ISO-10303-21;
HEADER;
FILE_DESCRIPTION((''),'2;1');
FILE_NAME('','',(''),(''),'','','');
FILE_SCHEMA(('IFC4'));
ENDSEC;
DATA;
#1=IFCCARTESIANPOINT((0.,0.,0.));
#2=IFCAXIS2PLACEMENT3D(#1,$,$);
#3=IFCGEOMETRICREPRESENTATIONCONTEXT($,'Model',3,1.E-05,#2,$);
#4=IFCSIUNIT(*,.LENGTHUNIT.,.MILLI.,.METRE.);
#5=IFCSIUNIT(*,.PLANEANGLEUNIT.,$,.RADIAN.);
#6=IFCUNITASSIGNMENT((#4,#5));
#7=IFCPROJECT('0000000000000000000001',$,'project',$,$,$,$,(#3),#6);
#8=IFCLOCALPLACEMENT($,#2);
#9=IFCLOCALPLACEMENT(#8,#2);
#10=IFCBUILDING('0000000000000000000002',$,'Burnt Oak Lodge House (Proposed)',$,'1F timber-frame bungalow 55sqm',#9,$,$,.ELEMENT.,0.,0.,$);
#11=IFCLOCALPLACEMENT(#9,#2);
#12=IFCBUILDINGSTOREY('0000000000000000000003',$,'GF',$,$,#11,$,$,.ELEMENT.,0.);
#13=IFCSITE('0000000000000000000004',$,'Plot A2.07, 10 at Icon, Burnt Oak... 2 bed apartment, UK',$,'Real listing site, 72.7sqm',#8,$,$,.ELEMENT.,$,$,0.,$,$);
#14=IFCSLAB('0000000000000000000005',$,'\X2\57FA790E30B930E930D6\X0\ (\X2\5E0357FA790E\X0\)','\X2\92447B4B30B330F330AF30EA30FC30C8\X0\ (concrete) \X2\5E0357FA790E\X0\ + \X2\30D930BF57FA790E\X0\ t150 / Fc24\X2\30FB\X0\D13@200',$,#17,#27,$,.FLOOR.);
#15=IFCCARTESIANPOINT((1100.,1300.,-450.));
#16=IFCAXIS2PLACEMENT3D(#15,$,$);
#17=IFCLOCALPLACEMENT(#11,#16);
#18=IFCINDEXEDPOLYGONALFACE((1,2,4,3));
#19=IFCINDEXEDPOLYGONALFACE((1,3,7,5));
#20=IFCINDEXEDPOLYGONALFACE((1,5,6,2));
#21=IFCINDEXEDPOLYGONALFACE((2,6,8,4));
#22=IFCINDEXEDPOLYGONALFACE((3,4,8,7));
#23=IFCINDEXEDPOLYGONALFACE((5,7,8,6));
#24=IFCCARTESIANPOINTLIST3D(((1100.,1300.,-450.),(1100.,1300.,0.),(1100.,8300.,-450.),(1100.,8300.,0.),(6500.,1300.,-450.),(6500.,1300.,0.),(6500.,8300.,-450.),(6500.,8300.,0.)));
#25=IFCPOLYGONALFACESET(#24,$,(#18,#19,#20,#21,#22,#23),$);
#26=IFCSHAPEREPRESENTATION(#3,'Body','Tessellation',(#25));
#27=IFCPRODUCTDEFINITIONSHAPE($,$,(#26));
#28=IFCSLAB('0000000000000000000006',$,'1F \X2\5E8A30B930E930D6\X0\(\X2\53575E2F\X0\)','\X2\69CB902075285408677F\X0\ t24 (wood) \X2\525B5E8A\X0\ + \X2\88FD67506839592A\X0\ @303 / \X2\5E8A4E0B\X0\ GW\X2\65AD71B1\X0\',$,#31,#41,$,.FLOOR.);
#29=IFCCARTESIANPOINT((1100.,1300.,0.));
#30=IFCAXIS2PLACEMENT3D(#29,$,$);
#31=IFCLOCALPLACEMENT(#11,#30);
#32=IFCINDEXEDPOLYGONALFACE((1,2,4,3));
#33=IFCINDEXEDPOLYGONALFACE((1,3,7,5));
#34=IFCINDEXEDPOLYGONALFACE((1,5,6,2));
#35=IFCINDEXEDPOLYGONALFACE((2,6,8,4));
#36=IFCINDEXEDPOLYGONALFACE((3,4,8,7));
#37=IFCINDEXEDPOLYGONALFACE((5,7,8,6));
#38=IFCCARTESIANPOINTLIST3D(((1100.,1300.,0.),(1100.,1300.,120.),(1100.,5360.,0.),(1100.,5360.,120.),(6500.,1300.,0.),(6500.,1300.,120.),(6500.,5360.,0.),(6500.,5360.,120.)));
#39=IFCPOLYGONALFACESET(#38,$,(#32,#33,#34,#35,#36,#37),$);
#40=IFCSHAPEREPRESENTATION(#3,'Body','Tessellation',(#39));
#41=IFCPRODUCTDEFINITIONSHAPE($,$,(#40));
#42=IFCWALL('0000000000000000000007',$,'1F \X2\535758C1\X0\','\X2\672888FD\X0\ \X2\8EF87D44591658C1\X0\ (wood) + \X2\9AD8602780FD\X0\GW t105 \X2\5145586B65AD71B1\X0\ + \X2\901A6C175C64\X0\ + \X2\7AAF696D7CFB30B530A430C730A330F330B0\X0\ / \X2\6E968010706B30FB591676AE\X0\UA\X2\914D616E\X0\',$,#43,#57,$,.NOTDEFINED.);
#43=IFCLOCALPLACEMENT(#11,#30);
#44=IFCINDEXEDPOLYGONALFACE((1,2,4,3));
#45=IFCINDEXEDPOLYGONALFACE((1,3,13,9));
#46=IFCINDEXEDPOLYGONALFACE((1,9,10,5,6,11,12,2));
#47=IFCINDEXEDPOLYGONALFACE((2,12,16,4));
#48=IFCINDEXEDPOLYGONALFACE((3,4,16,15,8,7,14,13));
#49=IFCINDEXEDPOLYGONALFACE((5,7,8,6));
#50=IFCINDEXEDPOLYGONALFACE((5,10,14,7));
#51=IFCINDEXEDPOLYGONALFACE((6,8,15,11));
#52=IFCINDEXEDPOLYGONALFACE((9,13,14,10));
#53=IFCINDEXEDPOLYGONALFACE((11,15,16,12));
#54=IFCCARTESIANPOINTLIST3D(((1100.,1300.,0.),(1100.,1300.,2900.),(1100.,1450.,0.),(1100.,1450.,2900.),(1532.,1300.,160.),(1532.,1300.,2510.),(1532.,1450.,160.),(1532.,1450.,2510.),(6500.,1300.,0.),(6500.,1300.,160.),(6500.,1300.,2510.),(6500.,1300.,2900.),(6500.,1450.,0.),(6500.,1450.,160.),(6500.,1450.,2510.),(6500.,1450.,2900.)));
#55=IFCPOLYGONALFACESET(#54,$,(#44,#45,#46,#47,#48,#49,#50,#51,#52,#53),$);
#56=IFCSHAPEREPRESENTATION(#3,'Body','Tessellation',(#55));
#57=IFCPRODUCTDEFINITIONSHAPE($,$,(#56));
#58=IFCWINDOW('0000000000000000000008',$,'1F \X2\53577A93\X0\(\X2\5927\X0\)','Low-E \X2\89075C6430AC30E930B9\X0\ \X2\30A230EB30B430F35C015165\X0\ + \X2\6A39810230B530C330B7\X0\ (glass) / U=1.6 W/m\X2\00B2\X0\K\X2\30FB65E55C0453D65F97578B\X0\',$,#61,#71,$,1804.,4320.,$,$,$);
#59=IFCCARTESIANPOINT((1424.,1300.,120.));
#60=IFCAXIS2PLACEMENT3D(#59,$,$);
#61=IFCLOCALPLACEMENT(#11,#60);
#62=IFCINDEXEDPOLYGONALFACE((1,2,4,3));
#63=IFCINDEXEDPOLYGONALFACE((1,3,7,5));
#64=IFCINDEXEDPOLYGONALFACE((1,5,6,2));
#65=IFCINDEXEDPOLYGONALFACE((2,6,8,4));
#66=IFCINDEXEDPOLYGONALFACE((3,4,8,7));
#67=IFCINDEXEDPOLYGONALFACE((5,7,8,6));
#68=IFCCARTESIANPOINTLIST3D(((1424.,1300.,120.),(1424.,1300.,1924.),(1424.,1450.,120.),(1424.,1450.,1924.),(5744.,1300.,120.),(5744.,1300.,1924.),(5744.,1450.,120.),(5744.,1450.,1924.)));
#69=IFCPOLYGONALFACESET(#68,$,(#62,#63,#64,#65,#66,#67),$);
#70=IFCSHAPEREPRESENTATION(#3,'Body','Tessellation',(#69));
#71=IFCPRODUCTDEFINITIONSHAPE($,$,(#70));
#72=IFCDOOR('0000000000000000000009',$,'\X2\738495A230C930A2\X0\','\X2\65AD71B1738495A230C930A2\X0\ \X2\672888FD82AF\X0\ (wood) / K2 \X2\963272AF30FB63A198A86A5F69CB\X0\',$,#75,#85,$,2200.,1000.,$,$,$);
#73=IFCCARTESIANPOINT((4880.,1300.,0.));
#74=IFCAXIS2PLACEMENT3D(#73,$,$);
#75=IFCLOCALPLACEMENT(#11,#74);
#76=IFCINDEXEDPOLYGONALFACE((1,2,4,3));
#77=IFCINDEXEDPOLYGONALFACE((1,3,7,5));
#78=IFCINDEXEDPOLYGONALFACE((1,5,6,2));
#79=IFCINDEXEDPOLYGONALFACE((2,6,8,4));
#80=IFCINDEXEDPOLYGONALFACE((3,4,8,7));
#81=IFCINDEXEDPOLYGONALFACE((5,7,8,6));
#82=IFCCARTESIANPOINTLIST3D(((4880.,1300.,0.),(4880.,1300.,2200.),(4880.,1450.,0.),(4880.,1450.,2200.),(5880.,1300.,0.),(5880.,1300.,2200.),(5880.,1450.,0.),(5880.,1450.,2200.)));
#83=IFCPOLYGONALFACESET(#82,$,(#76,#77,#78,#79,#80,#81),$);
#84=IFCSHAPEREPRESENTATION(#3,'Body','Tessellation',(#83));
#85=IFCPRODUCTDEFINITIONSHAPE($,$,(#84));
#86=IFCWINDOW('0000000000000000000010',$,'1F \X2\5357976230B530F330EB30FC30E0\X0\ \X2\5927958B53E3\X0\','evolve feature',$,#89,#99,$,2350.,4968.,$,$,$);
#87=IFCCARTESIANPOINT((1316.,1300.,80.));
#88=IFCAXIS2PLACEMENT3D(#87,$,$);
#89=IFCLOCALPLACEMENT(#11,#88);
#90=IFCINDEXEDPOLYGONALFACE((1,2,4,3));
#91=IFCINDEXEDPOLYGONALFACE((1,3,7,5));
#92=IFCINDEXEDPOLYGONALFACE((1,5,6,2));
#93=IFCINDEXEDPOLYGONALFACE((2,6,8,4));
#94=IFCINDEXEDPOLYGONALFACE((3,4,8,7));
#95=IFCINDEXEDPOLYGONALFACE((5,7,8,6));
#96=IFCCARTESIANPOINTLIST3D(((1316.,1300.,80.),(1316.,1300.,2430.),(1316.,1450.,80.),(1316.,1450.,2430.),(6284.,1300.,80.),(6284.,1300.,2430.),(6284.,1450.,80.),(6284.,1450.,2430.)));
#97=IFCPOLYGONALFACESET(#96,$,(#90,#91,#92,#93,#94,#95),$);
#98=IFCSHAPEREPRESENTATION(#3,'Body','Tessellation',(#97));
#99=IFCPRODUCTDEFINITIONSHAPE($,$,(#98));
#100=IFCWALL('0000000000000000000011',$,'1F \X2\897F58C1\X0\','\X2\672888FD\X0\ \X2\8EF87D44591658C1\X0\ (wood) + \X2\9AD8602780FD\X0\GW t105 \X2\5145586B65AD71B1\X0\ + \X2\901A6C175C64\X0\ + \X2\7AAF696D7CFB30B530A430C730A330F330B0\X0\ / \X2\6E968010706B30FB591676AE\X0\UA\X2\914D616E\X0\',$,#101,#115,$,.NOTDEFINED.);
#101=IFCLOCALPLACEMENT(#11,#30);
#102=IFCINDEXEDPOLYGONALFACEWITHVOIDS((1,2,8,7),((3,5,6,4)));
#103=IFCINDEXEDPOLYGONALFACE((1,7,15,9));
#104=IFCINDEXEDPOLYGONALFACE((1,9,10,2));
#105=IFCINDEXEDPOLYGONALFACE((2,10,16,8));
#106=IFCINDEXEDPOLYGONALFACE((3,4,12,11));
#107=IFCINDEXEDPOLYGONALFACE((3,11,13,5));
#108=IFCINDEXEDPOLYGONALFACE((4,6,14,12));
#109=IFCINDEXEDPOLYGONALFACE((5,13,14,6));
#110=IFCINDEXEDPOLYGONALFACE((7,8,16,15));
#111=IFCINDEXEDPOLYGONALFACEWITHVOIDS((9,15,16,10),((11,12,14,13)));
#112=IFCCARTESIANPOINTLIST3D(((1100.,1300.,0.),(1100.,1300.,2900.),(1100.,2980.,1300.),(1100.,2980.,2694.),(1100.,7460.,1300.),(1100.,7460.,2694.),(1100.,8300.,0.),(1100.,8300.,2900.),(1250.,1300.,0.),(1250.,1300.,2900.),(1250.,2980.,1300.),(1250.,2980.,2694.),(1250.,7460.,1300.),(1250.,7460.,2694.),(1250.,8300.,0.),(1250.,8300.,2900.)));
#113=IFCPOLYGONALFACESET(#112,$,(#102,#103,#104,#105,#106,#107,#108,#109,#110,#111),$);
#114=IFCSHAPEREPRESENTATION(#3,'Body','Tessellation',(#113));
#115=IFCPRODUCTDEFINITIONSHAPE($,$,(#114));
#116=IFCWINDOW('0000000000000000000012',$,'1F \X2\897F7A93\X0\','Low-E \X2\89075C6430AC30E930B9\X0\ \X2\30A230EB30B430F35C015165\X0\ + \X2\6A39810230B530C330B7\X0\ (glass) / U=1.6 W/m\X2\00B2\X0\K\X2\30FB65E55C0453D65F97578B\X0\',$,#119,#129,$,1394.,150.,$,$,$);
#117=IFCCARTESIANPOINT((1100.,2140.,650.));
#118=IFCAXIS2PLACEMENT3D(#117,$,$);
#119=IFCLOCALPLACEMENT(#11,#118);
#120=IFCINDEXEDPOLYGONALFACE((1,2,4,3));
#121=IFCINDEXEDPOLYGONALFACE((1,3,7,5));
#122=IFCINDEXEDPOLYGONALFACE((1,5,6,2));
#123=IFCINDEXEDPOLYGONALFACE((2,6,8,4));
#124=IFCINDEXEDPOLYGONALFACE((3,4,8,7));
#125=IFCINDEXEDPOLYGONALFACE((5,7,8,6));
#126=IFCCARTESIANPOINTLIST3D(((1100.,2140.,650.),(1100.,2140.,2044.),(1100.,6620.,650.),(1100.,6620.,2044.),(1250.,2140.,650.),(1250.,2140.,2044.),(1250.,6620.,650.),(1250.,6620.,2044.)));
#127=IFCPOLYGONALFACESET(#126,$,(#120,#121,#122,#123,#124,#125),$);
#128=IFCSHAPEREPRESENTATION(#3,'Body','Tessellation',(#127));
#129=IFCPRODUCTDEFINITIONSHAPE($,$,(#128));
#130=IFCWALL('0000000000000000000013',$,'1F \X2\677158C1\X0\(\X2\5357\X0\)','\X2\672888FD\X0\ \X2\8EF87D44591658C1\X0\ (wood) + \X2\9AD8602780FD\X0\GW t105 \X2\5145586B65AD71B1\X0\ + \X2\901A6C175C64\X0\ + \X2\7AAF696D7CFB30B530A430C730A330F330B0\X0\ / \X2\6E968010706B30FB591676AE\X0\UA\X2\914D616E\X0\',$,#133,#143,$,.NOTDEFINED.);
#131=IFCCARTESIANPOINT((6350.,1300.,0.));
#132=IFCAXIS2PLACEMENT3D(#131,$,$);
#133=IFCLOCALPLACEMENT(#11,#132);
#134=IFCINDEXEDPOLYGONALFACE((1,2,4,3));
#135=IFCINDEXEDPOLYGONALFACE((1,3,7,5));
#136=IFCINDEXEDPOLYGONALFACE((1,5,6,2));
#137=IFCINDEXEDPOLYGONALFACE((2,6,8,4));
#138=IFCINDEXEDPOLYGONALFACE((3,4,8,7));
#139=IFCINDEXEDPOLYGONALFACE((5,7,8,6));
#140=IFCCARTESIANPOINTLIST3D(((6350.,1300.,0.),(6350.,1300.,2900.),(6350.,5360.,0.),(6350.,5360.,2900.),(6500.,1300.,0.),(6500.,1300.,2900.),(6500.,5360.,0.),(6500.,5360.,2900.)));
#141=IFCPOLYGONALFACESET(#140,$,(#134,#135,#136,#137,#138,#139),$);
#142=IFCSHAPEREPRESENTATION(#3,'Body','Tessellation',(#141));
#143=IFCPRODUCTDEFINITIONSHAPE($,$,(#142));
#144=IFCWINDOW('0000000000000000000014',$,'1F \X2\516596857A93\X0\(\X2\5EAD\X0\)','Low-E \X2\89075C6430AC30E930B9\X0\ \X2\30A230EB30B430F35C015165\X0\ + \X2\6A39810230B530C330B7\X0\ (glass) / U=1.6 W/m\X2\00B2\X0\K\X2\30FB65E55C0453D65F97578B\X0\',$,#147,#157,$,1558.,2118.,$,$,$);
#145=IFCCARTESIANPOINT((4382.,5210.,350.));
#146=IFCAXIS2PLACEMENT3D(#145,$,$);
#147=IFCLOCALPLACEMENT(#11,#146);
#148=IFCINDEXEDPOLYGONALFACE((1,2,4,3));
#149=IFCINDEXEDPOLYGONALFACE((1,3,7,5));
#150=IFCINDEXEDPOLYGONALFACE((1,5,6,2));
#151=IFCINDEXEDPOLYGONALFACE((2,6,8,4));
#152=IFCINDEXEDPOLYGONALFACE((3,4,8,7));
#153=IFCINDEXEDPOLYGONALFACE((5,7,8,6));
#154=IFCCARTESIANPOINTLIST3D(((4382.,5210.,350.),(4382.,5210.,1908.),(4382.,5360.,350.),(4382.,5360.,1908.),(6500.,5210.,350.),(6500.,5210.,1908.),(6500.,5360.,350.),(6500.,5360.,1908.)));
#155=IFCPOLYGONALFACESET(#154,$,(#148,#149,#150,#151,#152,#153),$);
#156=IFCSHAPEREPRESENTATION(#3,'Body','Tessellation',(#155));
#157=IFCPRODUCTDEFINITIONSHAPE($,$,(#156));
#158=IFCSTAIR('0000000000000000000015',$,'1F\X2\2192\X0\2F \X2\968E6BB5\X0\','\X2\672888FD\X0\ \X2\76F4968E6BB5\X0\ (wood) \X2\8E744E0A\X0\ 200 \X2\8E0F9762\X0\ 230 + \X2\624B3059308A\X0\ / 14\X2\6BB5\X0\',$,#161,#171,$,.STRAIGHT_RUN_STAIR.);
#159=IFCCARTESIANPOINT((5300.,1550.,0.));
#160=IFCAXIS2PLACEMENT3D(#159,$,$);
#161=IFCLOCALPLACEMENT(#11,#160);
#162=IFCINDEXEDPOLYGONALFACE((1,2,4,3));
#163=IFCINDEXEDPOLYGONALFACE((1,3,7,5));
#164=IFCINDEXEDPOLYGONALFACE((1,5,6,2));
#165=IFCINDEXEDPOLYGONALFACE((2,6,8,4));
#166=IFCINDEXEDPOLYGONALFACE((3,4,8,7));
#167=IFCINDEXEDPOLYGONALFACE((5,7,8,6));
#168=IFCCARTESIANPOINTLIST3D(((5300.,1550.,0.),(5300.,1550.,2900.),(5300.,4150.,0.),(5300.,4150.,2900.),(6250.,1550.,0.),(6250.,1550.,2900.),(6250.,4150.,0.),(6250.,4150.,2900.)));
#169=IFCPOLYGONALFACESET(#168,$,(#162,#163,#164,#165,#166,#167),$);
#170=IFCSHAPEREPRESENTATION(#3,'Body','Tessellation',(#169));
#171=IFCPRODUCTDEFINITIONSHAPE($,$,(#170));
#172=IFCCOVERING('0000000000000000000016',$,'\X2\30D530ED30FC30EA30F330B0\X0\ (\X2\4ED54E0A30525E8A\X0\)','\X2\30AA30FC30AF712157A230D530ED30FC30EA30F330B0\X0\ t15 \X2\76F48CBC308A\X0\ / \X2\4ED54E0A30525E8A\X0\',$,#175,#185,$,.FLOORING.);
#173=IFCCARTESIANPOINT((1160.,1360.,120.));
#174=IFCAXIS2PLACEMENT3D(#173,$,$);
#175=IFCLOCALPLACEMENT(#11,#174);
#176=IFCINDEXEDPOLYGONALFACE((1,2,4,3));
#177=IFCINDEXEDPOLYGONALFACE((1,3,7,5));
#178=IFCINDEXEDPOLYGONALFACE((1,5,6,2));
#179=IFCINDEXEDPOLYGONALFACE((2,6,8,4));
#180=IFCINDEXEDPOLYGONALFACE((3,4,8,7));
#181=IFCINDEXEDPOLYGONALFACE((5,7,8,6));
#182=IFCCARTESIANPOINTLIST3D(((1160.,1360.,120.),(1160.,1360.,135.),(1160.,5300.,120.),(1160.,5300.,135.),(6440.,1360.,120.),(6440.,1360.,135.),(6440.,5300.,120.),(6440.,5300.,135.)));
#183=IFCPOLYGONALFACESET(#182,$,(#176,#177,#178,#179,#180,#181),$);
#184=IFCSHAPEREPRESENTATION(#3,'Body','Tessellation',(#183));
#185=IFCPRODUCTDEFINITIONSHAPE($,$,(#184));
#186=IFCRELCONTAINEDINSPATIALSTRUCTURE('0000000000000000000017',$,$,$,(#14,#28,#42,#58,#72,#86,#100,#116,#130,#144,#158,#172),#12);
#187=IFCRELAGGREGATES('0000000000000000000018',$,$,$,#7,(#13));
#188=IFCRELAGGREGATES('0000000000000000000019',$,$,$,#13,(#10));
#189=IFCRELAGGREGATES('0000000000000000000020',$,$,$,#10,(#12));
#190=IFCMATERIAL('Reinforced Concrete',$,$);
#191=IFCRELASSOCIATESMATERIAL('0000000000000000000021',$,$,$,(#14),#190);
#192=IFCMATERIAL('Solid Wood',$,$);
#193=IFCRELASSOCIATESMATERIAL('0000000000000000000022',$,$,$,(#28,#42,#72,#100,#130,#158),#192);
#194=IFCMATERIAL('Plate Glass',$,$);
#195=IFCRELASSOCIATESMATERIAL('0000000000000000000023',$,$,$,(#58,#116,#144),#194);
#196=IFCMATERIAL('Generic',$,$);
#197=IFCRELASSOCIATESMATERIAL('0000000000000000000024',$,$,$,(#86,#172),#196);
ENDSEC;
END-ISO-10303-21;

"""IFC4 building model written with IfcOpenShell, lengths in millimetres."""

from ifc_helpers import new_model, si_unit, frame, frame_2d, origin, place, context, project, spatial, rectangle, extrude, material, element, fill, save


model = new_model("IFC4")

# Units and contexts
model_context = context("Model", 3, precision=1e-05, world=origin())
ifc_project = project(units=[si_unit("LENGTHUNIT", "METRE", prefix="MILLI"), si_unit("PLANEANGLEUNIT", "RADIAN")], contexts=[model_context])

# Site, building, storey
site_placement = place(None, origin())
site = spatial("IfcSite", under=ifc_project, at=site_placement, Name="Plot A2.07, 10 at Icon, Burnt Oak... 2 bed apartment, UK", ObjectType="Real listing site, 72.7sqm", CompositionType="ELEMENT", RefElevation=0.0)
building_placement = place(site_placement, origin())
building = spatial("IfcBuilding", under=site, at=building_placement, Name="Burnt Oak Lodge House (Proposed)", ObjectType="1F timber-frame bungalow 55sqm", CompositionType="ELEMENT", ElevationOfRefHeight=0.0, ElevationOfTerrain=0.0)
storey_placement = place(building_placement, origin())
storey = spatial("IfcBuildingStorey", under=building, at=storey_placement, Name="GF", CompositionType="ELEMENT", Elevation=0.0)

# Slabs
ifc_material_1 = material(Name="Reinforced Concrete")
slab_1_placement = place(storey_placement, frame((1100.0, 1300.0, -450.0)))
element("IfcSlab", 1, at=slab_1_placement, inside=storey, material=ifc_material_1, Name="基礎スラブ (布基礎)", Description="鉄筋コンクリート (concrete) 布基礎 + ベタ基礎 t150 / Fc24・D13@200", PredefinedType="FLOOR", context=model_context, shape_type="SweptSolid", body=[
    extrude(rectangle(XDim=5400.0, YDim=7000.0, at=frame_2d((2700.0, 3500.0))), frame((1100.0, 1300.0, -450.0)), (0.0, 0.0, 1.0), 450.0),
])
ifc_material_2 = material(Name="Solid Wood")
slab_2_placement = place(storey_placement, frame((1100.0, 1300.0, 0.0)))
element("IfcSlab", 2, at=slab_2_placement, inside=storey, material=ifc_material_2, Name="1F 床スラブ(南帯)", Description="構造用合板 t24 (wood) 剛床 + 製材根太 @303 / 床下 GW断熱", PredefinedType="FLOOR", context=model_context, shape_type="SweptSolid", body=[
    extrude(rectangle(XDim=5400.0, YDim=4060.0, at=frame_2d((2700.0, 2030.0))), frame((1100.0, 1300.0, 0.0)), (0.0, 0.0, 1.0), 120.0),
])

# Wall, openings, windows, door
wall_1_placement = place(storey_placement, frame((1100.0, 1300.0, 0.0)))
wall_1 = element("IfcWall", 3, at=wall_1_placement, inside=storey, material=ifc_material_2, Name="1F 南壁", Description="木製 軸組外壁 (wood) + 高性能GW t105 充填断熱 + 通気層 + 窯業系サイディング / 準耐火・外皮UA配慮", PredefinedType="NOTDEFINED", context=model_context, shape_type="SweptSolid", body=[
    extrude(rectangle(XDim=5400.0, YDim=150.0, at=frame_2d((2700.0, 75.0))), frame((1100.0, 1300.0, 0.0)), (0.0, 0.0, 1.0), 2900.0),
])
opening_1_placement = place(storey_placement, frame((1424.0, 1300.0, 120.0)))
opening_1 = element("IfcOpeningElement", 4, at=opening_1_placement, cuts=wall_1, PredefinedType="NOTDEFINED", context=model_context, shape_type="SweptSolid", body=[
    extrude(rectangle(XDim=4320.0, YDim=150.0, at=frame_2d((2160.0, 75.0))), frame((1424.0, 1300.0, 120.0)), (0.0, 0.0, 1.0), 1804.0),
])
opening_2_placement = place(storey_placement, frame((4880.0, 1300.0, 0.0)))
opening_2 = element("IfcOpeningElement", 5, at=opening_2_placement, cuts=wall_1, PredefinedType="NOTDEFINED", context=model_context, shape_type="SweptSolid", body=[
    extrude(rectangle(XDim=1000.0, YDim=150.0, at=frame_2d((500.0, 75.0))), frame((4880.0, 1300.0, 0.0)), (0.0, 0.0, 1.0), 2200.0),
])
opening_3_placement = place(storey_placement, frame((1316.0, 1300.0, 80.0)))
opening_3 = element("IfcOpeningElement", 6, at=opening_3_placement, cuts=wall_1, PredefinedType="NOTDEFINED", context=model_context, shape_type="SweptSolid", body=[
    extrude(rectangle(XDim=4968.0, YDim=150.0, at=frame_2d((2484.0, 75.0))), frame((1316.0, 1300.0, 80.0)), (0.0, 0.0, 1.0), 2350.0),
])
ifc_material_3 = material(Name="Plate Glass")
window_1_placement = place(storey_placement, frame((1424.0, 1300.0, 120.0)))
window_1 = element("IfcWindow", 7, at=window_1_placement, inside=storey, material=ifc_material_3, Name="1F 南窓(大)", Description="Low-E 複層ガラス アルゴン封入 + 樹脂サッシ (glass) / U=1.6 W/m²K・日射取得型", OverallHeight=1804.0, OverallWidth=4320.0, context=model_context, shape_type="SweptSolid", body=[
    extrude(rectangle(XDim=4320.0, YDim=150.0, at=frame_2d((2160.0, 75.0))), frame((1424.0, 1300.0, 120.0)), (0.0, 0.0, 1.0), 1804.0),
])
fill(opening_1, window_1)
door_1_placement = place(storey_placement, frame((4880.0, 1300.0, 0.0)))
door_1 = element("IfcDoor", 8, at=door_1_placement, inside=storey, material=ifc_material_2, Name="玄関ドア", Description="断熱玄関ドア 木製芯 (wood) / K2 防犯・採風機構", OverallHeight=2200.0, OverallWidth=1000.0, context=model_context, shape_type="SweptSolid", body=[
    extrude(rectangle(XDim=1000.0, YDim=150.0, at=frame_2d((500.0, 75.0))), frame((4880.0, 1300.0, 0.0)), (0.0, 0.0, 1.0), 2200.0),
])
fill(opening_2, door_1)
ifc_material_4 = material(Name="Generic")
window_2_placement = place(storey_placement, frame((1316.0, 1300.0, 80.0)))
window_2 = element("IfcWindow", 9, at=window_2_placement, inside=storey, material=ifc_material_4, Name="1F 南面サンルーム 大開口", Description="evolve feature", OverallHeight=2350.0, OverallWidth=4968.0, context=model_context, shape_type="SweptSolid", body=[
    extrude(rectangle(XDim=4968.0, YDim=150.0, at=frame_2d((2484.0, 75.0))), frame((1316.0, 1300.0, 80.0)), (0.0, 0.0, 1.0), 2350.0),
])
fill(opening_3, window_2)

# Walls, openings, windows
wall_2_placement = place(storey_placement, frame((1100.0, 1300.0, 0.0)))
wall_2 = element("IfcWall", 10, at=wall_2_placement, inside=storey, material=ifc_material_2, Name="1F 西壁", Description="木製 軸組外壁 (wood) + 高性能GW t105 充填断熱 + 通気層 + 窯業系サイディング / 準耐火・外皮UA配慮", PredefinedType="NOTDEFINED", context=model_context, shape_type="SweptSolid", body=[
    extrude(rectangle(XDim=150.0, YDim=7000.0, at=frame_2d((75.0, 3500.0))), frame((1100.0, 1300.0, 0.0)), (0.0, 0.0, 1.0), 2900.0),
])
opening_4_placement = place(storey_placement, frame((1100.0, 2140.0, 650.0)))
opening_4 = element("IfcOpeningElement", 11, at=opening_4_placement, cuts=wall_2, PredefinedType="NOTDEFINED", context=model_context, shape_type="SweptSolid", body=[
    extrude(rectangle(XDim=150.0, YDim=4480.0, at=frame_2d((75.0, 2240.0))), frame((1100.0, 2140.0, 650.0)), (0.0, 0.0, 1.0), 1394.0),
])
window_3_placement = place(storey_placement, frame((1100.0, 2140.0, 650.0)))
window_3 = element("IfcWindow", 12, at=window_3_placement, inside=storey, material=ifc_material_3, Name="1F 西窓", Description="Low-E 複層ガラス アルゴン封入 + 樹脂サッシ (glass) / U=1.6 W/m²K・日射取得型", OverallHeight=1394.0, OverallWidth=150.0, context=model_context, shape_type="SweptSolid", body=[
    extrude(rectangle(XDim=150.0, YDim=4480.0, at=frame_2d((75.0, 2240.0))), frame((1100.0, 2140.0, 650.0)), (0.0, 0.0, 1.0), 1394.0),
])
fill(opening_4, window_3)
wall_3_placement = place(storey_placement, frame((6350.0, 1300.0, 0.0)))
wall_3 = element("IfcWall", 13, at=wall_3_placement, inside=storey, material=ifc_material_2, Name="1F 東壁(南)", Description="木製 軸組外壁 (wood) + 高性能GW t105 充填断熱 + 通気層 + 窯業系サイディング / 準耐火・外皮UA配慮", PredefinedType="NOTDEFINED", context=model_context, shape_type="SweptSolid", body=[
    extrude(rectangle(XDim=150.0, YDim=4060.0, at=frame_2d((75.0, 2030.0))), frame((6350.0, 1300.0, 0.0)), (0.0, 0.0, 1.0), 2900.0),
])
opening_5_placement = place(storey_placement, frame((4382.0, 5210.0, 350.0)))
opening_5 = element("IfcOpeningElement", 14, at=opening_5_placement, cuts=wall_3, PredefinedType="NOTDEFINED", context=model_context, shape_type="SweptSolid", body=[
    extrude(rectangle(XDim=2118.0, YDim=150.0, at=frame_2d((1059.0, 75.0))), frame((4382.0, 5210.0, 350.0)), (0.0, 0.0, 1.0), 1558.0),
])
window_4_placement = place(storey_placement, frame((4382.0, 5210.0, 350.0)))
window_4 = element("IfcWindow", 15, at=window_4_placement, inside=storey, material=ifc_material_3, Name="1F 入隅窓(庭)", Description="Low-E 複層ガラス アルゴン封入 + 樹脂サッシ (glass) / U=1.6 W/m²K・日射取得型", OverallHeight=1558.0, OverallWidth=2118.0, context=model_context, shape_type="SweptSolid", body=[
    extrude(rectangle(XDim=2118.0, YDim=150.0, at=frame_2d((1059.0, 75.0))), frame((4382.0, 5210.0, 350.0)), (0.0, 0.0, 1.0), 1558.0),
])
fill(opening_5, window_4)

# Stair
stair_placement = place(storey_placement, frame((5300.0, 1550.0, 0.0)))
element("IfcStair", 16, at=stair_placement, inside=storey, material=ifc_material_2, Name="1F→2F 階段", Description="木製 直階段 (wood) 蹴上 200 踏面 230 + 手すり / 14段", PredefinedType="STRAIGHT_RUN_STAIR", context=model_context, shape_type="SweptSolid", body=[
    extrude(rectangle(XDim=950.0, YDim=2600.0, at=frame_2d((475.0, 1300.0))), frame((5300.0, 1550.0, 0.0)), (0.0, 0.0, 1.0), 2900.0),
])

# Covering
covering_placement = place(storey_placement, frame((1160.0, 1360.0, 120.0)))
element("IfcCovering", 17, at=covering_placement, inside=storey, material=ifc_material_4, Name="フローリング (仕上げ床)", Description="オーク無垢フローリング t15 直貼り / 仕上げ床", PredefinedType="FLOORING", context=model_context, shape_type="SweptSolid", body=[
    extrude(rectangle(XDim=5280.0, YDim=3940.0, at=frame_2d((2640.0, 1970.0))), frame((1160.0, 1360.0, 120.0)), (0.0, 0.0, 1.0), 15.0),
])

save(model, "model.ifc")
